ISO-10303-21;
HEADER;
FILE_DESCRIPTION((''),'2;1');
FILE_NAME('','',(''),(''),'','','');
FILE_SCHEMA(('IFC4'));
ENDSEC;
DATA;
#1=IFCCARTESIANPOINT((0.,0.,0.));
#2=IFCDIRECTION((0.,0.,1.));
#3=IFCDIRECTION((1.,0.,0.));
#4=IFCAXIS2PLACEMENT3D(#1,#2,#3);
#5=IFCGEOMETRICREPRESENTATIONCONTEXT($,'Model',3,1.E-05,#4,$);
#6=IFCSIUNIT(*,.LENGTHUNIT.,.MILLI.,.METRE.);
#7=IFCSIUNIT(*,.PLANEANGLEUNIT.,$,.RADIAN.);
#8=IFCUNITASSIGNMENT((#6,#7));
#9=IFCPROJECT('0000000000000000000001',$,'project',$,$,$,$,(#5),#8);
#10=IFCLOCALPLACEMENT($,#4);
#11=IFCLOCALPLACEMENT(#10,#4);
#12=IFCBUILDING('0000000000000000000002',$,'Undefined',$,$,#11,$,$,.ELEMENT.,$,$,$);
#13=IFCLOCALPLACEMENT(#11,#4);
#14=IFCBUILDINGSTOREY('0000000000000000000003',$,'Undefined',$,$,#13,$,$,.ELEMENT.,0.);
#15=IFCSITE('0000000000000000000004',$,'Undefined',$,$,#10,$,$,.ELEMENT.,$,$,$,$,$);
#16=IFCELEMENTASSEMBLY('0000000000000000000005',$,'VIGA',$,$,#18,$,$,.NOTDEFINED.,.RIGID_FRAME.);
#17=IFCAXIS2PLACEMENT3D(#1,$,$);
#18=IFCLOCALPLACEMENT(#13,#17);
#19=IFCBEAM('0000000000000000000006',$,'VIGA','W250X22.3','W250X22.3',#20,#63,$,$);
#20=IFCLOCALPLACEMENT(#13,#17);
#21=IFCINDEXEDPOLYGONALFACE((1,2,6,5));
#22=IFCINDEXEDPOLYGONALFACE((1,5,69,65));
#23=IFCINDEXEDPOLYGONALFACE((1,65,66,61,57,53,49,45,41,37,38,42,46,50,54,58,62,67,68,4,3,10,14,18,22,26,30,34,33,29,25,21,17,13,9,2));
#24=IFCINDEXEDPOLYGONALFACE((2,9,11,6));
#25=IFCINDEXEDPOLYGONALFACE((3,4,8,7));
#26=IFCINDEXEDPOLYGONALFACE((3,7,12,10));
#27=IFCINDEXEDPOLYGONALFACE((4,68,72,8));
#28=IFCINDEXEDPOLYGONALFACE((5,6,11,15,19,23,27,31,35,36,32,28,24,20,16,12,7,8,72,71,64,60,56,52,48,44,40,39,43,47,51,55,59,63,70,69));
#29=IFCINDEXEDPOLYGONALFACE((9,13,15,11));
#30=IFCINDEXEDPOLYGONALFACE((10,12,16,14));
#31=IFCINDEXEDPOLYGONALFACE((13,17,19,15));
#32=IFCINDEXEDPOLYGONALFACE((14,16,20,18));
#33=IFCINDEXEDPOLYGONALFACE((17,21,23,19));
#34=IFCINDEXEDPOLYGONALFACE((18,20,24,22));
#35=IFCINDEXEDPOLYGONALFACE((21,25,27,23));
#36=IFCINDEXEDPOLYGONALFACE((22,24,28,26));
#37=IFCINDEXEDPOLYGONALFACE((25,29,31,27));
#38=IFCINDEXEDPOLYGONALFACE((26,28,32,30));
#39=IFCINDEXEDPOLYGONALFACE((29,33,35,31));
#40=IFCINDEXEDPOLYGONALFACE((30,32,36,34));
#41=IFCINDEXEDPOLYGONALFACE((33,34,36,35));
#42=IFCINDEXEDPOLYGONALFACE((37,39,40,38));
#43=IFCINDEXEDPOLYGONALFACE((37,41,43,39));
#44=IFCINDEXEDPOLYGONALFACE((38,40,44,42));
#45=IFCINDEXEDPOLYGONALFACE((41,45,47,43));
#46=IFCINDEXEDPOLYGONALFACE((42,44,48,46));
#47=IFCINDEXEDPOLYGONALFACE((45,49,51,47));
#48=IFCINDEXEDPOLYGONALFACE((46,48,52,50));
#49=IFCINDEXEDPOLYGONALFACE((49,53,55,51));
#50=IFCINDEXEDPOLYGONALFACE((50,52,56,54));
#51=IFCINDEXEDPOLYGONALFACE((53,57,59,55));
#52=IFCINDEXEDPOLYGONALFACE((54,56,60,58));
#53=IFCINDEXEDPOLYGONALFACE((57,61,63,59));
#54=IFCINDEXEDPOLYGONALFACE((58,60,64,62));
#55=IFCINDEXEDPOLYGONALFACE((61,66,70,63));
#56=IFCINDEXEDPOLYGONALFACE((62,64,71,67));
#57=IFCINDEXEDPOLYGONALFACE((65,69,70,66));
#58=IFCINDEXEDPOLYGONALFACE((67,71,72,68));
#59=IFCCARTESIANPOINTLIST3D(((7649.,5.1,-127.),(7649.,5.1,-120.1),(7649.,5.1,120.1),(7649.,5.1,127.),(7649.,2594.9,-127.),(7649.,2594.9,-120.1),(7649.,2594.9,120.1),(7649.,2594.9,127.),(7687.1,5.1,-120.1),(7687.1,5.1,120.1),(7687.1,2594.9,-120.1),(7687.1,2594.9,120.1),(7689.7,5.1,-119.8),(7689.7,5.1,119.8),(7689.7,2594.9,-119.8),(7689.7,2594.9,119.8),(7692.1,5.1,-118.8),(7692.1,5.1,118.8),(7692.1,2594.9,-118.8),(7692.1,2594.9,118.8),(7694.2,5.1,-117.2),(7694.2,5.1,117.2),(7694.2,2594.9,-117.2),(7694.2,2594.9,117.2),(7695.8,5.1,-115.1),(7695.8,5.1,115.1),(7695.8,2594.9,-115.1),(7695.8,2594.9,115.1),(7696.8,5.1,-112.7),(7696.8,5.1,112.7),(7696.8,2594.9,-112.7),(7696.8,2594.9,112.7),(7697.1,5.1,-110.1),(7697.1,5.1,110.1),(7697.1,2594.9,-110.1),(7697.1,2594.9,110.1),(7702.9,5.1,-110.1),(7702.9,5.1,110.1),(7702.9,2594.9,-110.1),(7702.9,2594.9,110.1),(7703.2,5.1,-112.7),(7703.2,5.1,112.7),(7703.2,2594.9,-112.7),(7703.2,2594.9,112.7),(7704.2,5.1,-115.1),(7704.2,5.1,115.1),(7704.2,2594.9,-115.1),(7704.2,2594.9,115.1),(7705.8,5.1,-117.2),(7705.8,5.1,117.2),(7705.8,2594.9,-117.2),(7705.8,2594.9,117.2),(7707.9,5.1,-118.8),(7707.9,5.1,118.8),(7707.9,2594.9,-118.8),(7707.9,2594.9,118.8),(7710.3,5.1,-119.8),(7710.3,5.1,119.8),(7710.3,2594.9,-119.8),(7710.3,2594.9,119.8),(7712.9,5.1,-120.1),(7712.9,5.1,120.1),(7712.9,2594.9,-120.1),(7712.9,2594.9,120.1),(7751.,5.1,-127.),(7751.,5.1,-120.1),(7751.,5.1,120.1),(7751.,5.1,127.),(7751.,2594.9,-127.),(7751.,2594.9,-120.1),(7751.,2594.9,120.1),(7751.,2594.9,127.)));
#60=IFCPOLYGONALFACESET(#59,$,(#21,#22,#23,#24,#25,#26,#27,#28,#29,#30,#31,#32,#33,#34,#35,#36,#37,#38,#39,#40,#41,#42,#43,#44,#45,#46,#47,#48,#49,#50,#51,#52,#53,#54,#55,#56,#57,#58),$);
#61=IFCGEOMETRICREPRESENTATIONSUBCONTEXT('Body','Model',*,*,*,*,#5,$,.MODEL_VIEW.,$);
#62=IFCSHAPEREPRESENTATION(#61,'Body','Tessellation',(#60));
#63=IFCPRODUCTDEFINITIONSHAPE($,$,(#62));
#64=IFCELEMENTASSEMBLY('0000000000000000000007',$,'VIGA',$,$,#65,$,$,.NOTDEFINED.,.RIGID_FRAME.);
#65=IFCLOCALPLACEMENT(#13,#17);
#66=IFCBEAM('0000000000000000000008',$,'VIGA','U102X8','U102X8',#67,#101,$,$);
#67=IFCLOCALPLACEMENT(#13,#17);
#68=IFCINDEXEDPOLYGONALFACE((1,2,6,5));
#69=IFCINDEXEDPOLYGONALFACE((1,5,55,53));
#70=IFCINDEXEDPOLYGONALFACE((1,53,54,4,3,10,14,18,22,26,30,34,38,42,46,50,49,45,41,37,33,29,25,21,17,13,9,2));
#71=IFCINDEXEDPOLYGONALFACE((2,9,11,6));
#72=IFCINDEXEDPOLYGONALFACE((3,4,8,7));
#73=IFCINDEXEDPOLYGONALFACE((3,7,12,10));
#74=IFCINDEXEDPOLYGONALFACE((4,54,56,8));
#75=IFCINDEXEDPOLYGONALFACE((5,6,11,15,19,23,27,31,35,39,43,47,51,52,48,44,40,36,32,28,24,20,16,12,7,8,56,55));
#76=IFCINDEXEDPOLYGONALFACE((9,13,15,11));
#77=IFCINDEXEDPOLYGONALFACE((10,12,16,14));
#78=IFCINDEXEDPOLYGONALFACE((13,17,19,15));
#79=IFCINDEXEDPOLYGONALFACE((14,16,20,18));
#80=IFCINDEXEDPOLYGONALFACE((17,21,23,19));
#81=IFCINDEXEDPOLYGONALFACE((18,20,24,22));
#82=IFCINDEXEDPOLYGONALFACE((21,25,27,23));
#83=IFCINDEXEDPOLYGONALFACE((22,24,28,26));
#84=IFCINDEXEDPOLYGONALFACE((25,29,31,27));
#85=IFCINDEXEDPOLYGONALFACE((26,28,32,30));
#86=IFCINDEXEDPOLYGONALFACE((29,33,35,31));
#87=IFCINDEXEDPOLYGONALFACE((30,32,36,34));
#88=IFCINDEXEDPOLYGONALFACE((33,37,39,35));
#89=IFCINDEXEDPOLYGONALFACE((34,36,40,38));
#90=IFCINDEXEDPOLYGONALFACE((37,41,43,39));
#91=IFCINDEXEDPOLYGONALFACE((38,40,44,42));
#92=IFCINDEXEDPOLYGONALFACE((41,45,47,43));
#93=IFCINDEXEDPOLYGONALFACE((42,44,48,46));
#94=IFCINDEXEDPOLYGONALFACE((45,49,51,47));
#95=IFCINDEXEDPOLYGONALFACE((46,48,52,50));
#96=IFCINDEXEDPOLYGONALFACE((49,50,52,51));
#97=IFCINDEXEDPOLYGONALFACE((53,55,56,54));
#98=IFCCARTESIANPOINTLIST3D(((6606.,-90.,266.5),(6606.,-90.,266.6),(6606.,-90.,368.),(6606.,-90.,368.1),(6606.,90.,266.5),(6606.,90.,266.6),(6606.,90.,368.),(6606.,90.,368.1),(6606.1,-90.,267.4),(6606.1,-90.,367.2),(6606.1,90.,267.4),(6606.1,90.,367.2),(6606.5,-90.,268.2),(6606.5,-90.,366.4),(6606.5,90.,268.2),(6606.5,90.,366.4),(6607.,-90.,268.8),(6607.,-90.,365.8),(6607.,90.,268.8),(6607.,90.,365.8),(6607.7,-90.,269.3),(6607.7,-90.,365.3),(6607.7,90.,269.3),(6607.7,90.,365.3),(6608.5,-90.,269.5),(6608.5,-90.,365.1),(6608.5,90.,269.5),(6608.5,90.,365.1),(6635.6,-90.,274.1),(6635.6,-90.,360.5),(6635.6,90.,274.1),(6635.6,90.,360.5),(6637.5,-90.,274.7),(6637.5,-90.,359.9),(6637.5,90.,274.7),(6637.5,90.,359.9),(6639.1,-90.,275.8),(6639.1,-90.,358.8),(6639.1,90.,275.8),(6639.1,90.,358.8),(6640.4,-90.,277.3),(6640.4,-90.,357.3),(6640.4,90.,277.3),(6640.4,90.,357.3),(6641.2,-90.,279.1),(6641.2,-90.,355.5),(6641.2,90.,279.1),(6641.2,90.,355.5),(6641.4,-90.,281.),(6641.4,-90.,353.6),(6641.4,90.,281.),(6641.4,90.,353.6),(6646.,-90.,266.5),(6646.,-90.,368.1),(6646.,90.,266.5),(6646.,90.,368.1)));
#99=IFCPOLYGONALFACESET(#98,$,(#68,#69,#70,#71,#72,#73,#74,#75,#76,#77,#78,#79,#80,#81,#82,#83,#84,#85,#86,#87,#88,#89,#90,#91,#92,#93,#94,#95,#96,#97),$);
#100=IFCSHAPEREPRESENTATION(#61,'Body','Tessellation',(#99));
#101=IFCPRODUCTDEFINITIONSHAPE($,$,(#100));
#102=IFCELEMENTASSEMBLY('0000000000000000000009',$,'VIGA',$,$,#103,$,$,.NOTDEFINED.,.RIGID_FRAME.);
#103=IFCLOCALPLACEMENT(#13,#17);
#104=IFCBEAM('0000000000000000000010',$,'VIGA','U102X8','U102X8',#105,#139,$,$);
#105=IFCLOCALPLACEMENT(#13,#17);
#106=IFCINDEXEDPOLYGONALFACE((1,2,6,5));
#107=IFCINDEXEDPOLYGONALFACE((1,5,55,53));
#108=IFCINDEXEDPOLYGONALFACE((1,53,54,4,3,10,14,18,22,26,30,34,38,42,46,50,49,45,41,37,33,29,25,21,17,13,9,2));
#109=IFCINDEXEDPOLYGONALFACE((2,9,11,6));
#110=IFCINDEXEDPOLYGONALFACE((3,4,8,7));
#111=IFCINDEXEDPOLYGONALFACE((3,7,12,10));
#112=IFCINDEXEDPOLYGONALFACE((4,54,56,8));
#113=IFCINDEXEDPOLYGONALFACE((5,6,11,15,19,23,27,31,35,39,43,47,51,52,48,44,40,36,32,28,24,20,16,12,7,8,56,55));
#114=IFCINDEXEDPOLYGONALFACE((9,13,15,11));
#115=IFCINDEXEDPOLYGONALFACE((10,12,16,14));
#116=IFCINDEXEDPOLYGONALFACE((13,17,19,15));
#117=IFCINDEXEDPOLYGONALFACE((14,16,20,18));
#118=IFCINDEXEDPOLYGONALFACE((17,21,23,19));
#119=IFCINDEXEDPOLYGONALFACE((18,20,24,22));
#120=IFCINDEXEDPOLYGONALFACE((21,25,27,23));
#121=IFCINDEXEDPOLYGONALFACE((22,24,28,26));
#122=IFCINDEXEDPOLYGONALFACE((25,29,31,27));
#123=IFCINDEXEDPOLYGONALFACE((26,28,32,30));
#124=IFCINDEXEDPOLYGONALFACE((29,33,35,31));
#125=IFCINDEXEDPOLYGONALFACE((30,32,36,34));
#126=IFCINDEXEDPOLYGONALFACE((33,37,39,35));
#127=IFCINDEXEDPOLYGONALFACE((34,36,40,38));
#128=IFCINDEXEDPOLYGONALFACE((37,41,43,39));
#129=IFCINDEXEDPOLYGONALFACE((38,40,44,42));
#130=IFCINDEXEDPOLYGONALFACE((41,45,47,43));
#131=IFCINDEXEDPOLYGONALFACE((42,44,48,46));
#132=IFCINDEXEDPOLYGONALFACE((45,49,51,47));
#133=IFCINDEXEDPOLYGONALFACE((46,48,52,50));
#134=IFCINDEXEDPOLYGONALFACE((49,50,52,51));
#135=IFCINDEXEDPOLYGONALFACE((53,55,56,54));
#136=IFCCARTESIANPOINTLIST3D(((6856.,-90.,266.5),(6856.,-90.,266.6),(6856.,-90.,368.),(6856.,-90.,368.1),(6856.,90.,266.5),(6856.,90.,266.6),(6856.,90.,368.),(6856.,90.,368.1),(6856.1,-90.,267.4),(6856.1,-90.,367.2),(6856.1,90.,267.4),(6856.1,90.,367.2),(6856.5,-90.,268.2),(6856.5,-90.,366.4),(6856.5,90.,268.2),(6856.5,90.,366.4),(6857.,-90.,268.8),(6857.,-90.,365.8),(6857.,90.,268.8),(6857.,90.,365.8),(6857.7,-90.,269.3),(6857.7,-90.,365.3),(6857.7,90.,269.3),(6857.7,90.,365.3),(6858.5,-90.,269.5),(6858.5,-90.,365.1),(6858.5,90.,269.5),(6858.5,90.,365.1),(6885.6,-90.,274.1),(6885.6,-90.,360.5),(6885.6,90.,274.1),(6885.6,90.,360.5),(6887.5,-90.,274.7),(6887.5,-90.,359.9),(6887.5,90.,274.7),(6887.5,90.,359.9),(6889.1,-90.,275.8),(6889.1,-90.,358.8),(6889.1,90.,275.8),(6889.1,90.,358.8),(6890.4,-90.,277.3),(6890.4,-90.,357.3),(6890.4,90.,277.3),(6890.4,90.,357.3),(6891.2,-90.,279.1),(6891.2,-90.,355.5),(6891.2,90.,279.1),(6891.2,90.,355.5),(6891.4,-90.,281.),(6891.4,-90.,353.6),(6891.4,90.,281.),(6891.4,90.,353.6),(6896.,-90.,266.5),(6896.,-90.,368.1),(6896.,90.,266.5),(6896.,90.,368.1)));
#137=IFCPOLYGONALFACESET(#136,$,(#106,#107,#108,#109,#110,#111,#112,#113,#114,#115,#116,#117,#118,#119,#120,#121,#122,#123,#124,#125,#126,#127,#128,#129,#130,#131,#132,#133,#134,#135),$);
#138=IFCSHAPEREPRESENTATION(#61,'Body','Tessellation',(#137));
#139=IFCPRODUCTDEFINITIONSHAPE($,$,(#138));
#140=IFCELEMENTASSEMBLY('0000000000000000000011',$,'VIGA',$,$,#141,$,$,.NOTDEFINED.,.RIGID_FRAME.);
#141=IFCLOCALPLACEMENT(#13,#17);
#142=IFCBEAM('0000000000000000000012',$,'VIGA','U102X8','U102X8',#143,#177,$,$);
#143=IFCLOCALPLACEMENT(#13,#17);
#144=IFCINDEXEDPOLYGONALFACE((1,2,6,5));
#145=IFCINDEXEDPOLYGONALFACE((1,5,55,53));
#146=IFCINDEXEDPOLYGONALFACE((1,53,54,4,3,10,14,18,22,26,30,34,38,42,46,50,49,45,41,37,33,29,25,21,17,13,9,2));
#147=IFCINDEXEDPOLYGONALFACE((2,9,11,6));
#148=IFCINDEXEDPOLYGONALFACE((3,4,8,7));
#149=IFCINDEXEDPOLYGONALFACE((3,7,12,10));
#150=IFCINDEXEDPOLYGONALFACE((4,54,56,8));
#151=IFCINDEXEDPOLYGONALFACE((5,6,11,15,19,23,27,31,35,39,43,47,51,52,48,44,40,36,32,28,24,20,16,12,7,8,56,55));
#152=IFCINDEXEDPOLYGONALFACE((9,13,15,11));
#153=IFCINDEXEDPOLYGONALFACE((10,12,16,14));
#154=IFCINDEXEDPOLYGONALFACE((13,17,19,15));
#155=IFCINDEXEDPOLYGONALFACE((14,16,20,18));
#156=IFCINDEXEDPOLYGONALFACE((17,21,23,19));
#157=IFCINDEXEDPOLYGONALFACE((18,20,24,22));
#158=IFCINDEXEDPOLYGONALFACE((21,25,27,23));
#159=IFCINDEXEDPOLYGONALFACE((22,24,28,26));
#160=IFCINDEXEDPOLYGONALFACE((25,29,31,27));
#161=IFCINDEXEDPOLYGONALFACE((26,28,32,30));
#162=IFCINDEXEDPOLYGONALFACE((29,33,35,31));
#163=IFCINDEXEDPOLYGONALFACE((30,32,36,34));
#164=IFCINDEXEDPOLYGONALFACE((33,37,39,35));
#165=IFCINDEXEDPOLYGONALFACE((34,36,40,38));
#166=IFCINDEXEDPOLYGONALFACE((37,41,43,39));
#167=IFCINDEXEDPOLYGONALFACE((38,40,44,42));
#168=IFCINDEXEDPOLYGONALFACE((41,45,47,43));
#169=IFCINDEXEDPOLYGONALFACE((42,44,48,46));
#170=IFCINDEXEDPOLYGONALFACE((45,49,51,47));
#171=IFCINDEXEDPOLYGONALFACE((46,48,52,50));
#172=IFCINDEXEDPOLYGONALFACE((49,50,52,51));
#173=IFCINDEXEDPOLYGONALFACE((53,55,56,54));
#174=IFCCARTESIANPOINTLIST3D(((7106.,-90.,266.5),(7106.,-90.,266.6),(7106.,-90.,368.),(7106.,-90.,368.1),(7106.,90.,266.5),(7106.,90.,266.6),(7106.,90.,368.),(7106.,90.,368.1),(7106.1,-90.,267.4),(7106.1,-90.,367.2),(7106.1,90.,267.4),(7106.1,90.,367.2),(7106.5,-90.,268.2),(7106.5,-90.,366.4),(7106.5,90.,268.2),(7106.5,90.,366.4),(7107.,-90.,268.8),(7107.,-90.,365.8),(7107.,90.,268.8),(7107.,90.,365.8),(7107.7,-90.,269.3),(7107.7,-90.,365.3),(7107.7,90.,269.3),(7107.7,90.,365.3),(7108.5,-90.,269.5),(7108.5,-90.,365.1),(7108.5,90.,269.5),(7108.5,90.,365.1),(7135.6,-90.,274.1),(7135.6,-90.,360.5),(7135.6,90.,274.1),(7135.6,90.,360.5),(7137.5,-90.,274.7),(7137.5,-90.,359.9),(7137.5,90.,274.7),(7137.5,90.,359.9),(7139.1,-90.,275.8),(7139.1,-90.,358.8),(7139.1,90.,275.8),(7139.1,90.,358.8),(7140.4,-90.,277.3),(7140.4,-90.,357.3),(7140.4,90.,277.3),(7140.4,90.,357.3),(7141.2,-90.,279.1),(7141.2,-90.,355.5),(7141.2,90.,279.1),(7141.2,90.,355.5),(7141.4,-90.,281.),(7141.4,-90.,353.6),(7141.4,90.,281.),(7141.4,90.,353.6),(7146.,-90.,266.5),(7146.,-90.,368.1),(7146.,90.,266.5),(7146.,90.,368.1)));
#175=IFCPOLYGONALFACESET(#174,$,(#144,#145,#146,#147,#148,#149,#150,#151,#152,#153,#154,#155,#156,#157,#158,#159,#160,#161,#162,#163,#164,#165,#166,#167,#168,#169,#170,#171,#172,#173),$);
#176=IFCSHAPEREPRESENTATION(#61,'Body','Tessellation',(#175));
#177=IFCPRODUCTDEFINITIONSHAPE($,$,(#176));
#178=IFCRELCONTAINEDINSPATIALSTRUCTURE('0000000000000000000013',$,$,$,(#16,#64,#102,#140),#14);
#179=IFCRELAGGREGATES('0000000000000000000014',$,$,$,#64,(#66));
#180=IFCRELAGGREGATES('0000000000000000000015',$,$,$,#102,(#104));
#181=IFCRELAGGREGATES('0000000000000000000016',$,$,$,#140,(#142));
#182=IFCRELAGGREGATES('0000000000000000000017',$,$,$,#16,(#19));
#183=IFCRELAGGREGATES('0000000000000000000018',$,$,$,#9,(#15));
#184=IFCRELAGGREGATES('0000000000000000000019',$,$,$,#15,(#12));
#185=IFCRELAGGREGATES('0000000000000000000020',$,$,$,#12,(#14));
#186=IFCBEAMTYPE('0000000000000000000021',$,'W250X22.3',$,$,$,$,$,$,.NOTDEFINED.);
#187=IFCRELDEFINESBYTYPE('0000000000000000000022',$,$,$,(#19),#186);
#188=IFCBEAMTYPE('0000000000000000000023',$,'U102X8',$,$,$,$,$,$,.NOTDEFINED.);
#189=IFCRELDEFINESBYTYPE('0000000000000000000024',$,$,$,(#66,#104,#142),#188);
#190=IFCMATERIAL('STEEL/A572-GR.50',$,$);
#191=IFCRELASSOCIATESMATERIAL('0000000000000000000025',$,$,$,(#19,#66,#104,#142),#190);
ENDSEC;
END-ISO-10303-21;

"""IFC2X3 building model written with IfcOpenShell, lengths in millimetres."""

from ifc_helpers import new_model, si_unit, frame, origin_with_axes, origin_2d_with_axis, place, context, subcontext, project, spatial, i_section, u_section, extrude, material, type_object, element, aggregate, save


model = new_model("IFC2X3")

# Units and contexts
model_context = context("Model", 3, precision=1e-05, world=origin_with_axes())
body_context = subcontext(model_context, "Body", "Model", "MODEL_VIEW")
ifc_project = project(units=[si_unit("LENGTHUNIT", "METRE", prefix="MILLI"), si_unit("PLANEANGLEUNIT", "RADIAN")], contexts=[model_context])

# Site, building, storey
site_placement = place(None, origin_with_axes())
site = spatial("IfcSite", under=ifc_project, at=site_placement, Name="Undefined", CompositionType="ELEMENT")
building_placement = place(site_placement, origin_with_axes())
building = spatial("IfcBuilding", under=site, at=building_placement, Name="Undefined", CompositionType="ELEMENT")
storey_placement = place(building_placement, origin_with_axes())
storey = spatial("IfcBuildingStorey", under=building, at=storey_placement, Name="Undefined", CompositionType="ELEMENT", Elevation=0.0)

# Element assemblies, beams
assembly_1_placement = place(storey_placement, origin_with_axes())
assembly_1 = element("IfcElementAssembly", 1, at=assembly_1_placement, inside=storey, Name="VIGA", AssemblyPlace="NOTDEFINED", PredefinedType="RIGID_FRAME")
ifc_material_1 = material(Name="STEEL/A572-GR.50")
beam_type_1 = type_object("IfcBeamType", Name="W250X22.3", PredefinedType="NOTDEFINED")
beam_1_placement = place(assembly_1_placement, frame((7700.0, 5.1, 0.0), z_axis=(0.0, 0.0, 1.0), x_axis=(0.0, 1.0, 0.0)))
beam_1 = element("IfcBeam", 2, at=beam_1_placement, type_object=beam_type_1, material=ifc_material_1, Name="VIGA", Description="W250X22.3", ObjectType="W250X22.3", context=body_context, shape_type="SweptSolid", body=[
    extrude(i_section(OverallWidth=102.0, OverallDepth=254.0, WebThickness=5.8, FlangeThickness=6.9, FilletRadius=10.0, at=origin_2d_with_axis()), frame((2589.8, 0.0, 0.0), z_axis=(-1.0, 0.0, 0.0), x_axis=(0.0, -1.0, 0.0)), (0.0, 0.0, 1.0), 2589.8),
])
assembly_2_placement = place(storey_placement, origin_with_axes())
assembly_2 = element("IfcElementAssembly", 3, at=assembly_2_placement, inside=storey, Name="VIGA", AssemblyPlace="NOTDEFINED", PredefinedType="RIGID_FRAME")
beam_type_2 = type_object("IfcBeamType", Name="U102X8", PredefinedType="NOTDEFINED")
beam_2_placement = place(assembly_2_placement, frame((6626.0, 90.0, 317.3), z_axis=(0.0, 0.0, 1.0), x_axis=(0.0, -1.0, 0.0)))
beam_2 = element("IfcBeam", 4, at=beam_2_placement, type_object=beam_type_2, material=ifc_material_1, Name="VIGA", Description="U102X8", ObjectType="U102X8", context=body_context, shape_type="SweptSolid", body=[
    extrude(u_section(Depth=101.6, FlangeWidth=40.0, WebThickness=4.6, FlangeThickness=6.0, FilletRadius=7.0, EdgeRadius=3.0, FlangeSlope=0.16839, at=origin_2d_with_axis()), frame((180.0, 0.0, 0.0), z_axis=(-1.0, 0.0, 0.0), x_axis=(0.0, -1.0, 0.0)), (0.0, 0.0, 1.0), 180.0),
])
aggregate(assembly_2, [beam_2])
assembly_3_placement = place(storey_placement, origin_with_axes())
assembly_3 = element("IfcElementAssembly", 5, at=assembly_3_placement, inside=storey, Name="VIGA", AssemblyPlace="NOTDEFINED", PredefinedType="RIGID_FRAME")
beam_3_placement = place(assembly_3_placement, frame((6876.0, 90.0, 317.3), z_axis=(0.0, 0.0, 1.0), x_axis=(0.0, -1.0, 0.0)))
beam_3 = element("IfcBeam", 6, at=beam_3_placement, type_object=beam_type_2, material=ifc_material_1, Name="VIGA", Description="U102X8", ObjectType="U102X8", context=body_context, shape_type="SweptSolid", body=[
    extrude(u_section(Depth=101.6, FlangeWidth=40.0, WebThickness=4.6, FlangeThickness=6.0, FilletRadius=7.0, EdgeRadius=3.0, FlangeSlope=0.16839, at=origin_2d_with_axis()), frame((180.0, 0.0, 0.0), z_axis=(-1.0, 0.0, 0.0), x_axis=(0.0, -1.0, 0.0)), (0.0, 0.0, 1.0), 180.0),
])
aggregate(assembly_3, [beam_3])
assembly_4_placement = place(storey_placement, origin_with_axes())
assembly_4 = element("IfcElementAssembly", 7, at=assembly_4_placement, inside=storey, Name="VIGA", AssemblyPlace="NOTDEFINED", PredefinedType="RIGID_FRAME")
beam_4_placement = place(assembly_4_placement, frame((7126.0, 90.0, 317.3), z_axis=(0.0, 0.0, 1.0), x_axis=(0.0, -1.0, 0.0)))
beam_4 = element("IfcBeam", 8, at=beam_4_placement, type_object=beam_type_2, material=ifc_material_1, Name="VIGA", Description="U102X8", ObjectType="U102X8", context=body_context, shape_type="SweptSolid", body=[
    extrude(u_section(Depth=101.6, FlangeWidth=40.0, WebThickness=4.6, FlangeThickness=6.0, FilletRadius=7.0, EdgeRadius=3.0, FlangeSlope=0.16839, at=origin_2d_with_axis()), frame((180.0, 0.0, 0.0), z_axis=(-1.0, 0.0, 0.0), x_axis=(0.0, -1.0, 0.0)), (0.0, 0.0, 1.0), 180.0),
])
aggregate(assembly_4, [beam_4])

aggregate(assembly_1, [beam_1])

save(model, "model.ifc")
